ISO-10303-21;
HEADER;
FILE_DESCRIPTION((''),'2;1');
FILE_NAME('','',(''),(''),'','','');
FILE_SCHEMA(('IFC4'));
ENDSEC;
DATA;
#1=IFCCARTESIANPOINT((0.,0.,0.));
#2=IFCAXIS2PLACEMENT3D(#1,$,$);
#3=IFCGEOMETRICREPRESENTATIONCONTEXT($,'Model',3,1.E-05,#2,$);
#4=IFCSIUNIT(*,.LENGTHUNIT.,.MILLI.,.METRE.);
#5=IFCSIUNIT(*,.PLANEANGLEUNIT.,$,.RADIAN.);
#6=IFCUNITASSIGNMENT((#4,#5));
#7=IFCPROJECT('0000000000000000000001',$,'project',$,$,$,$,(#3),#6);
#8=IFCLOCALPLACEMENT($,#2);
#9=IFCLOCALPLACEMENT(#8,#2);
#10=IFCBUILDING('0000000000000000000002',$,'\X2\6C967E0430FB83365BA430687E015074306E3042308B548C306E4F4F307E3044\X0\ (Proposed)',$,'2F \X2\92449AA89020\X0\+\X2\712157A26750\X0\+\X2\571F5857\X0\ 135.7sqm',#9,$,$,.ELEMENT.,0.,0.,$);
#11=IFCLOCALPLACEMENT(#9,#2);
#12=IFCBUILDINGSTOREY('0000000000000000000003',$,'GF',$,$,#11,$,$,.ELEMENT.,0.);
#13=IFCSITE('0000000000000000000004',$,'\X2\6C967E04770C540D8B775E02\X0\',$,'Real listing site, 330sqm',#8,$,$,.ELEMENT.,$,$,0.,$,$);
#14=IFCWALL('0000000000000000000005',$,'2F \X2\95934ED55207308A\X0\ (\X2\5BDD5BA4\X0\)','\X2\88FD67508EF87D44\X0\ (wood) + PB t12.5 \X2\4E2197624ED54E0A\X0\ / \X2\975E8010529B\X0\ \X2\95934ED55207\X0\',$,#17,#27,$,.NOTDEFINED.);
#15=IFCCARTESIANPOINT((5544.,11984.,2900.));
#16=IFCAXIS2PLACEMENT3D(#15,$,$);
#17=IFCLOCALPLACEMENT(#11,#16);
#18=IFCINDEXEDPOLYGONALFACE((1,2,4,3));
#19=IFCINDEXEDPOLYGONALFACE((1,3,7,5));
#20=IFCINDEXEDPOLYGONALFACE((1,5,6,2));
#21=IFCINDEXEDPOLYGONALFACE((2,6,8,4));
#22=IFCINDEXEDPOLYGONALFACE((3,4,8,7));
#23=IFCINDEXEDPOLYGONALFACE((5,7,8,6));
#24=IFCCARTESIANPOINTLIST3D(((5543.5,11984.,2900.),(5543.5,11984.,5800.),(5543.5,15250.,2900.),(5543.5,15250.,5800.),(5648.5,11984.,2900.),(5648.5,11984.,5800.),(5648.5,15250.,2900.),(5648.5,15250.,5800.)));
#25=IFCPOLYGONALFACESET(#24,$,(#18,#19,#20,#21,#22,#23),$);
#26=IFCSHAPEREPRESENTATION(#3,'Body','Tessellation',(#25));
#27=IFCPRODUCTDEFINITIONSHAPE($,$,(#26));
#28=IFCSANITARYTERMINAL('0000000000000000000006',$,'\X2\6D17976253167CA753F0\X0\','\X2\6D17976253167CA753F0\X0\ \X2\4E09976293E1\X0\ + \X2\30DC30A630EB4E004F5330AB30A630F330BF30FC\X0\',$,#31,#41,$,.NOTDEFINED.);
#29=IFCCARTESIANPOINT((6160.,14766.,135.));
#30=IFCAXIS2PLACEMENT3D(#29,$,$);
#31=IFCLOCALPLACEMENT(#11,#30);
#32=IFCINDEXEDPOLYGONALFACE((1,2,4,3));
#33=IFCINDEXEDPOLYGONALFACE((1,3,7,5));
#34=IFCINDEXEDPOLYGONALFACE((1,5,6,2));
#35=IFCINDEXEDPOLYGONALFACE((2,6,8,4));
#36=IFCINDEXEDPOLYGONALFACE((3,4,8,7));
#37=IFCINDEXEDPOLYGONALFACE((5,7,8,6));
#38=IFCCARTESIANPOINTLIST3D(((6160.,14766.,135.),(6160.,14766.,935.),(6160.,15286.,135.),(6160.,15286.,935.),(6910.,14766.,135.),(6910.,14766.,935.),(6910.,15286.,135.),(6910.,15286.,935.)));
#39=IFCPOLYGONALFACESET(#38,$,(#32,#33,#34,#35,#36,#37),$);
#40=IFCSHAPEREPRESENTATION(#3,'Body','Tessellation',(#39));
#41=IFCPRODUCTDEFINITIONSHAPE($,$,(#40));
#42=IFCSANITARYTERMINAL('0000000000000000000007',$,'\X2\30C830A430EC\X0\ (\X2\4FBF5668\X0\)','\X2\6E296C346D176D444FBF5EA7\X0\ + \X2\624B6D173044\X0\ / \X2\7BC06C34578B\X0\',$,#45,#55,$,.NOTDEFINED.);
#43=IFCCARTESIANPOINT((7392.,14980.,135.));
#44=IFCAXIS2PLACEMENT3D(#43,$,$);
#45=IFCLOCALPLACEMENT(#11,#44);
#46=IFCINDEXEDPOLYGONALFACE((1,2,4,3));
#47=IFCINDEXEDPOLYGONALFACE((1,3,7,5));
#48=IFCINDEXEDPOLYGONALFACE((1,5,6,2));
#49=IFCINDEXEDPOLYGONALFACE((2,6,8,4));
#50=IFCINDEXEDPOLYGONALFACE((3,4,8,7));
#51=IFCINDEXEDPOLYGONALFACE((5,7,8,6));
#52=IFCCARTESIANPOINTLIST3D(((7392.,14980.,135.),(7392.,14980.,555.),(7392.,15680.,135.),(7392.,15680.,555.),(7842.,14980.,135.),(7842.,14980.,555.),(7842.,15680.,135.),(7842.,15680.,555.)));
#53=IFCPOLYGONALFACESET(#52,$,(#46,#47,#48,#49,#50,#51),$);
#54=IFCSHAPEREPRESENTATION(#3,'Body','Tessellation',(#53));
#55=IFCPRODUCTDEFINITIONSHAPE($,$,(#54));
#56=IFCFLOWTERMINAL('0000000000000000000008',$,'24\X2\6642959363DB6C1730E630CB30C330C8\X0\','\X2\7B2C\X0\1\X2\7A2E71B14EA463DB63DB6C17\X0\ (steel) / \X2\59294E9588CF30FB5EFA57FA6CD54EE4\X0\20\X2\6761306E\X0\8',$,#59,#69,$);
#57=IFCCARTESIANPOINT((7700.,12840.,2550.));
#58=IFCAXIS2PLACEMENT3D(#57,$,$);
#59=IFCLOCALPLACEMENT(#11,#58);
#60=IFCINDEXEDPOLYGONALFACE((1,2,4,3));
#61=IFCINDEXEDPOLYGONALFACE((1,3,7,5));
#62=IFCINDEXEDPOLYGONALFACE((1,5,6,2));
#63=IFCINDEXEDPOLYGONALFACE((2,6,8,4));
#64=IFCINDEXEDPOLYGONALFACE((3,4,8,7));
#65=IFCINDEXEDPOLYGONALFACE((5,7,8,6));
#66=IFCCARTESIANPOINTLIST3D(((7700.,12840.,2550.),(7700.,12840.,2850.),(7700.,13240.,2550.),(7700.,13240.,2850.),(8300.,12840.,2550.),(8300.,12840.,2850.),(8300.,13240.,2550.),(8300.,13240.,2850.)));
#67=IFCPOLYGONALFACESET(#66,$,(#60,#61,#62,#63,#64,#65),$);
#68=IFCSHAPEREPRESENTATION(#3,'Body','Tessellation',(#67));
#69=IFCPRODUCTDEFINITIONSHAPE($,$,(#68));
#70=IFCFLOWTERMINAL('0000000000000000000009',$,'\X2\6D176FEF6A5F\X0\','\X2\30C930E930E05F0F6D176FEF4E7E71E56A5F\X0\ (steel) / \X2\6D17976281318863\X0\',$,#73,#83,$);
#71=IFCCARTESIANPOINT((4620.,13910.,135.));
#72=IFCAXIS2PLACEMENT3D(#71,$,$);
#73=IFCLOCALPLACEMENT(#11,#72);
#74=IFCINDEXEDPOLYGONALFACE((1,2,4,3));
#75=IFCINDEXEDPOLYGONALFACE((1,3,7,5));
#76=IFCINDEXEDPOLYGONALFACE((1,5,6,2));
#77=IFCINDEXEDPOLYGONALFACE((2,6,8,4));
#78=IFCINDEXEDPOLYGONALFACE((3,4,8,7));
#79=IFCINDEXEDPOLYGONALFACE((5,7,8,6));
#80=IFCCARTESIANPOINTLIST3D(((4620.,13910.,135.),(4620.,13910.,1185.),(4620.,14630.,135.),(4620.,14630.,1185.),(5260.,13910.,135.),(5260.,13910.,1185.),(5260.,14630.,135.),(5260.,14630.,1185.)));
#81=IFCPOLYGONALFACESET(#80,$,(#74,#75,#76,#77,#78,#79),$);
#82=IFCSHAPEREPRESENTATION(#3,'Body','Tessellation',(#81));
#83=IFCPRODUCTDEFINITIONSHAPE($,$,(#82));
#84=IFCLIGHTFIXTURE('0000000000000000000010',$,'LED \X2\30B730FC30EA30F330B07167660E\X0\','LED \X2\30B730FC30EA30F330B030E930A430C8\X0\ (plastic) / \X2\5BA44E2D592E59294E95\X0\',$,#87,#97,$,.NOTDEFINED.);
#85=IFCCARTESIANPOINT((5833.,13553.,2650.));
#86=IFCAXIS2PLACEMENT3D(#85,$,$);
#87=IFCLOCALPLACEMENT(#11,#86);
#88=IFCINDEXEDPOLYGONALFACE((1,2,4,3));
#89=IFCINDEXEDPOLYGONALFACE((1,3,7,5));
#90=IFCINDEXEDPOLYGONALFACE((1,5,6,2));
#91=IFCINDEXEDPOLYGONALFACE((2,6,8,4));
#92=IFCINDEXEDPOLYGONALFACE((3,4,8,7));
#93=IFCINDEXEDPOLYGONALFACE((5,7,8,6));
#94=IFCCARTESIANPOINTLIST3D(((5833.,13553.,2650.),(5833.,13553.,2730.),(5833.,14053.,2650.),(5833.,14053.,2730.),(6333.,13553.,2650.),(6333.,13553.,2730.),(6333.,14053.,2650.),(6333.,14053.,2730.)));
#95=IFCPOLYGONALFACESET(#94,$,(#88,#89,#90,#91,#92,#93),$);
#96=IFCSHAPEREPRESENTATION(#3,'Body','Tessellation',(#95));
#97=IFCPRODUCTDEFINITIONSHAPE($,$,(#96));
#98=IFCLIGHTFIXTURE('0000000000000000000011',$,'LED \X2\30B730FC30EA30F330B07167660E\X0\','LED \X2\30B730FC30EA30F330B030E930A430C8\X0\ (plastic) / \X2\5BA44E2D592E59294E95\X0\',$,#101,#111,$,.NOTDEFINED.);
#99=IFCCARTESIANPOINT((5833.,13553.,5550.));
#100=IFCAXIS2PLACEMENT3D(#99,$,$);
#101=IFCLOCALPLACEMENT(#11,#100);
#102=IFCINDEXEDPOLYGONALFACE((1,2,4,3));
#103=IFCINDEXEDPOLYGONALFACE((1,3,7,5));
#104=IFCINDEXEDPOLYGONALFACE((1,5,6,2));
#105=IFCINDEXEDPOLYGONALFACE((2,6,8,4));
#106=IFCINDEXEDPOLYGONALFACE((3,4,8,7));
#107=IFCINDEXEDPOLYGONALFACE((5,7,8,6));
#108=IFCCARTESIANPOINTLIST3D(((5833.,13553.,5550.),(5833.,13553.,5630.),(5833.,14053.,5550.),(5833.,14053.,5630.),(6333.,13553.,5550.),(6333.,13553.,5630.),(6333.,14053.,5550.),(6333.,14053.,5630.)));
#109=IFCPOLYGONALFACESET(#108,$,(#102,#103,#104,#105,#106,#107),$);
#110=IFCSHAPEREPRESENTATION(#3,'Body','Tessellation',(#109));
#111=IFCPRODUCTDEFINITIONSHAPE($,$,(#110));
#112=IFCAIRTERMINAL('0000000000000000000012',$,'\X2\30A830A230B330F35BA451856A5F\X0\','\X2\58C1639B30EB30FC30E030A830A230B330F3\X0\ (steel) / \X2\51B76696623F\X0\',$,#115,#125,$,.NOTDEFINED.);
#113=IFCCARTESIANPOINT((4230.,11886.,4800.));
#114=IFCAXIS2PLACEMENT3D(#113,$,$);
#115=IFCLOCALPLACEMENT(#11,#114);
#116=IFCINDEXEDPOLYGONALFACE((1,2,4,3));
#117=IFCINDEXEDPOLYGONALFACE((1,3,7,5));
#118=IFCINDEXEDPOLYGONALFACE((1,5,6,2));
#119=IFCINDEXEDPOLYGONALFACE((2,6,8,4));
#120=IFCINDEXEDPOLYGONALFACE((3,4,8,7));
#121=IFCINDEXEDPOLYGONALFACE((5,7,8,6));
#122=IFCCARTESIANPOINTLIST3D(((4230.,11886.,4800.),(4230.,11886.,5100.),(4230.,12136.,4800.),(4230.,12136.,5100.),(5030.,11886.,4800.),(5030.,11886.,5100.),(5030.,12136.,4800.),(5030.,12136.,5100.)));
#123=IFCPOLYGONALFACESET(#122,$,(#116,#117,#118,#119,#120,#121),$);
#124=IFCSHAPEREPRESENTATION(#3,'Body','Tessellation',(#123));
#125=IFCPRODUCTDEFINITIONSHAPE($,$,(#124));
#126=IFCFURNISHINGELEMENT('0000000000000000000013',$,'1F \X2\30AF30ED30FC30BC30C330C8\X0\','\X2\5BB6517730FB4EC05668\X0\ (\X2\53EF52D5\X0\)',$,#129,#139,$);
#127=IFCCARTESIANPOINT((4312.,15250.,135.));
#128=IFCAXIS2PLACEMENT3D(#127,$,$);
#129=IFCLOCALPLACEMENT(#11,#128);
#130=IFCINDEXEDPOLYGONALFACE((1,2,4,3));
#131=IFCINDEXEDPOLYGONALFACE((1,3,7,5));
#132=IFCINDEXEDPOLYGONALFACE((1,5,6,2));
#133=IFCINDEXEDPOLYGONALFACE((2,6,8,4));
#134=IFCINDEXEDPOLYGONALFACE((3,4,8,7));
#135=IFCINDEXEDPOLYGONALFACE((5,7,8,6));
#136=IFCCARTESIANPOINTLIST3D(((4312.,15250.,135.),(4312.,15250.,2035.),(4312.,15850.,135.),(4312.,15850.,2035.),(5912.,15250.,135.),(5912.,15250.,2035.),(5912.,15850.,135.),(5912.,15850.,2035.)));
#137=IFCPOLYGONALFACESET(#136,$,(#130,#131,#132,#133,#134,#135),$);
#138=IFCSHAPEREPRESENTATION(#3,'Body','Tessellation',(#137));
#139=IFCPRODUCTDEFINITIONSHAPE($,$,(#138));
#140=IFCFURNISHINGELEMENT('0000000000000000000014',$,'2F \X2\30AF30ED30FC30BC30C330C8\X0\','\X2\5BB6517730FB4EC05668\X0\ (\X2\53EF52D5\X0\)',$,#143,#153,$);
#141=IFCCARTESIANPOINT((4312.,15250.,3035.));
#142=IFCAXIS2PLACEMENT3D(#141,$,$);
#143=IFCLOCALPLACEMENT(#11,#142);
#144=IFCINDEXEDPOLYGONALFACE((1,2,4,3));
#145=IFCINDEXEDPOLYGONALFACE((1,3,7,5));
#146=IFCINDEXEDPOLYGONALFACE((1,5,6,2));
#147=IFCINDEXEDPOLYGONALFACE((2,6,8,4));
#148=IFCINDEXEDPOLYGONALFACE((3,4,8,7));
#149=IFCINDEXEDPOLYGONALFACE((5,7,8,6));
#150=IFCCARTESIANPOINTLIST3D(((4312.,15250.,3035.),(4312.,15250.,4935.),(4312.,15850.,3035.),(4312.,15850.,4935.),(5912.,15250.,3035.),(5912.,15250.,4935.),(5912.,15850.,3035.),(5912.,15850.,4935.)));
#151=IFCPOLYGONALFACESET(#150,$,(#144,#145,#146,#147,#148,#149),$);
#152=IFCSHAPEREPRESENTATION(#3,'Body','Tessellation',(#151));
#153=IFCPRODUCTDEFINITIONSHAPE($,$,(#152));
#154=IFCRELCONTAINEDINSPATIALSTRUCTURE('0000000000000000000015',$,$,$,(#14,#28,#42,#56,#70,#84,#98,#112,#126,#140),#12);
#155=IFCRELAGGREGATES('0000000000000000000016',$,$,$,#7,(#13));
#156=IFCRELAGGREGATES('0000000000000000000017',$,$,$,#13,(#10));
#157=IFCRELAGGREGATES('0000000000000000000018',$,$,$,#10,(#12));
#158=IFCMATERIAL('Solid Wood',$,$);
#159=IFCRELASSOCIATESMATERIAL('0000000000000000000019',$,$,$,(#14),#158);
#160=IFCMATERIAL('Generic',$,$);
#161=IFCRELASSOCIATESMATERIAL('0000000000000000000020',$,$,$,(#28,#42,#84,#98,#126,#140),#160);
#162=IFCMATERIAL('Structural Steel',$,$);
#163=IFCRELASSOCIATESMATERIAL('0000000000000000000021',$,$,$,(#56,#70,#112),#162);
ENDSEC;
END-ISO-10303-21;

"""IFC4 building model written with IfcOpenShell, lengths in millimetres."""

from ifc_helpers import new_model, si_unit, frame, frame_2d, origin, place, context, project, spatial, rectangle, extrude, material, element, save


model = new_model("IFC4")

# Units and contexts
model_context = context("Model", 3, precision=1e-05, world=origin())
ifc_project = project(units=[si_unit("LENGTHUNIT", "METRE", prefix="MILLI"), si_unit("PLANEANGLEUNIT", "RADIAN")], contexts=[model_context])

# Site, building, storey
site_placement = place(None, origin())
site = spatial("IfcSite", under=ifc_project, at=site_placement, Name="沖縄県名護市", ObjectType="Real listing site, 330sqm", CompositionType="ELEMENT", RefElevation=0.0)
building_placement = place(site_placement, origin())
building = spatial("IfcBuilding", under=site, at=building_placement, Name="沖縄・茶室と縁側のある和の住まい (Proposed)", ObjectType="2F 鉄骨造+無垢材+土塗 135.7sqm", CompositionType="ELEMENT", ElevationOfRefHeight=0.0, ElevationOfTerrain=0.0)
storey_placement = place(building_placement, origin())
storey = spatial("IfcBuildingStorey", under=building, at=storey_placement, Name="GF", CompositionType="ELEMENT", Elevation=0.0)

# Shared definitions
ifc_material_1 = material(Name="Solid Wood")

# Wall
wall_1_placement = place(storey_placement, frame((5544.0, 11984.0, 2900.0)))
element("IfcWall", 1, at=wall_1_placement, inside=storey, material=ifc_material_1, Name="2F 間仕切り (寝室)", Description="製材軸組 (wood) + PB t12.5 両面仕上 / 非耐力 間仕切", PredefinedType="NOTDEFINED", context=model_context, shape_type="SweptSolid", body=[
    extrude(rectangle(XDim=105.0, YDim=3266.0, at=frame_2d((52.0, 1633.0))), frame((5544.0, 11984.0, 2900.0)), (0.0, 0.0, 1.0), 2900.0),
])

# Sanitary terminals
ifc_material_2 = material(Name="Generic")
sanitary_terminal_1_placement = place(storey_placement, frame((6160.0, 14766.0, 135.0)))
element("IfcSanitaryTerminal", 2, at=sanitary_terminal_1_placement, inside=storey, material=ifc_material_2, Name="洗面化粧台", Description="洗面化粧台 三面鏡 + ボウル一体カウンター", PredefinedType="NOTDEFINED", context=model_context, shape_type="SweptSolid", body=[
    extrude(rectangle(XDim=750.0, YDim=520.0, at=frame_2d((375.0, 260.0))), frame((6160.0, 14766.0, 135.0)), (0.0, 0.0, 1.0), 800.0),
])
sanitary_terminal_2_placement = place(storey_placement, frame((7392.0, 14980.0, 135.0)))
element("IfcSanitaryTerminal", 3, at=sanitary_terminal_2_placement, inside=storey, material=ifc_material_2, Name="トイレ (便器)", Description="温水洗浄便座 + 手洗い / 節水型", PredefinedType="NOTDEFINED", context=model_context, shape_type="SweptSolid", body=[
    extrude(rectangle(XDim=450.0, YDim=700.0, at=frame_2d((225.0, 350.0))), frame((7392.0, 14980.0, 135.0)), (0.0, 0.0, 1.0), 420.0),
])

# Flow terminals
ifc_material_3 = material(Name="Structural Steel")
flow_terminal_1_placement = place(storey_placement, frame((7700.0, 12840.0, 2550.0)))
element("IfcFlowTerminal", 4, at=flow_terminal_1_placement, inside=storey, material=ifc_material_3, Name="24時間換気ユニット", Description="第1種熱交換換気 (steel) / 天井裏・建基法令20条の8", context=model_context, shape_type="SweptSolid", body=[
    extrude(rectangle(XDim=600.0, YDim=400.0, at=frame_2d((300.0, 200.0))), frame((7700.0, 12840.0, 2550.0)), (0.0, 0.0, 1.0), 300.0),
])
flow_terminal_2_placement = place(storey_placement, frame((4620.0, 13910.0, 135.0)))
element("IfcFlowTerminal", 5, at=flow_terminal_2_placement, inside=storey, material=ifc_material_3, Name="洗濯機", Description="ドラム式洗濯乾燥機 (steel) / 洗面脱衣", context=model_context, shape_type="SweptSolid", body=[
    extrude(rectangle(XDim=640.0, YDim=720.0, at=frame_2d((320.0, 360.0))), frame((4620.0, 13910.0, 135.0)), (0.0, 0.0, 1.0), 1050.0),
])

# Light fixtures
light_fixture_1_placement = place(storey_placement, frame((5833.0, 13553.0, 2650.0)))
element("IfcLightFixture", 6, at=light_fixture_1_placement, inside=storey, material=ifc_material_2, Name="LED シーリング照明", Description="LED シーリングライト (plastic) / 室中央天井", PredefinedType="NOTDEFINED", context=model_context, shape_type="SweptSolid", body=[
    extrude(rectangle(XDim=500.0, YDim=500.0, at=frame_2d((250.0, 250.0))), frame((5833.0, 13553.0, 2650.0)), (0.0, 0.0, 1.0), 80.0),
])
light_fixture_2_placement = place(storey_placement, frame((5833.0, 13553.0, 5550.0)))
element("IfcLightFixture", 7, at=light_fixture_2_placement, inside=storey, material=ifc_material_2, Name="LED シーリング照明", Description="LED シーリングライト (plastic) / 室中央天井", PredefinedType="NOTDEFINED", context=model_context, shape_type="SweptSolid", body=[
    extrude(rectangle(XDim=500.0, YDim=500.0, at=frame_2d((250.0, 250.0))), frame((5833.0, 13553.0, 5550.0)), (0.0, 0.0, 1.0), 80.0),
])

# Air terminal
air_terminal_placement = place(storey_placement, frame((4230.0, 11886.0, 4800.0)))
element("IfcAirTerminal", 8, at=air_terminal_placement, inside=storey, material=ifc_material_3, Name="エアコン室内機", Description="壁掛ルームエアコン (steel) / 冷暖房", PredefinedType="NOTDEFINED", context=model_context, shape_type="SweptSolid", body=[
    extrude(rectangle(XDim=800.0, YDim=250.0, at=frame_2d((400.0, 125.0))), frame((4230.0, 11886.0, 4800.0)), (0.0, 0.0, 1.0), 300.0),
])

# Furnishing elements
furnishing_1_placement = place(storey_placement, frame((4312.0, 15250.0, 135.0)))
element("IfcFurnishingElement", 9, at=furnishing_1_placement, inside=storey, material=ifc_material_2, Name="1F クローゼット", Description="家具・什器 (可動)", context=model_context, shape_type="SweptSolid", body=[
    extrude(rectangle(XDim=1600.0, YDim=600.0, at=frame_2d((800.0, 300.0))), frame((4312.0, 15250.0, 135.0)), (0.0, 0.0, 1.0), 1900.0),
])
furnishing_2_placement = place(storey_placement, frame((4312.0, 15250.0, 3035.0)))
element("IfcFurnishingElement", 10, at=furnishing_2_placement, inside=storey, material=ifc_material_2, Name="2F クローゼット", Description="家具・什器 (可動)", context=model_context, shape_type="SweptSolid", body=[
    extrude(rectangle(XDim=1600.0, YDim=600.0, at=frame_2d((800.0, 300.0))), frame((4312.0, 15250.0, 3035.0)), (0.0, 0.0, 1.0), 1900.0),
])

save(model, "model.ifc")
